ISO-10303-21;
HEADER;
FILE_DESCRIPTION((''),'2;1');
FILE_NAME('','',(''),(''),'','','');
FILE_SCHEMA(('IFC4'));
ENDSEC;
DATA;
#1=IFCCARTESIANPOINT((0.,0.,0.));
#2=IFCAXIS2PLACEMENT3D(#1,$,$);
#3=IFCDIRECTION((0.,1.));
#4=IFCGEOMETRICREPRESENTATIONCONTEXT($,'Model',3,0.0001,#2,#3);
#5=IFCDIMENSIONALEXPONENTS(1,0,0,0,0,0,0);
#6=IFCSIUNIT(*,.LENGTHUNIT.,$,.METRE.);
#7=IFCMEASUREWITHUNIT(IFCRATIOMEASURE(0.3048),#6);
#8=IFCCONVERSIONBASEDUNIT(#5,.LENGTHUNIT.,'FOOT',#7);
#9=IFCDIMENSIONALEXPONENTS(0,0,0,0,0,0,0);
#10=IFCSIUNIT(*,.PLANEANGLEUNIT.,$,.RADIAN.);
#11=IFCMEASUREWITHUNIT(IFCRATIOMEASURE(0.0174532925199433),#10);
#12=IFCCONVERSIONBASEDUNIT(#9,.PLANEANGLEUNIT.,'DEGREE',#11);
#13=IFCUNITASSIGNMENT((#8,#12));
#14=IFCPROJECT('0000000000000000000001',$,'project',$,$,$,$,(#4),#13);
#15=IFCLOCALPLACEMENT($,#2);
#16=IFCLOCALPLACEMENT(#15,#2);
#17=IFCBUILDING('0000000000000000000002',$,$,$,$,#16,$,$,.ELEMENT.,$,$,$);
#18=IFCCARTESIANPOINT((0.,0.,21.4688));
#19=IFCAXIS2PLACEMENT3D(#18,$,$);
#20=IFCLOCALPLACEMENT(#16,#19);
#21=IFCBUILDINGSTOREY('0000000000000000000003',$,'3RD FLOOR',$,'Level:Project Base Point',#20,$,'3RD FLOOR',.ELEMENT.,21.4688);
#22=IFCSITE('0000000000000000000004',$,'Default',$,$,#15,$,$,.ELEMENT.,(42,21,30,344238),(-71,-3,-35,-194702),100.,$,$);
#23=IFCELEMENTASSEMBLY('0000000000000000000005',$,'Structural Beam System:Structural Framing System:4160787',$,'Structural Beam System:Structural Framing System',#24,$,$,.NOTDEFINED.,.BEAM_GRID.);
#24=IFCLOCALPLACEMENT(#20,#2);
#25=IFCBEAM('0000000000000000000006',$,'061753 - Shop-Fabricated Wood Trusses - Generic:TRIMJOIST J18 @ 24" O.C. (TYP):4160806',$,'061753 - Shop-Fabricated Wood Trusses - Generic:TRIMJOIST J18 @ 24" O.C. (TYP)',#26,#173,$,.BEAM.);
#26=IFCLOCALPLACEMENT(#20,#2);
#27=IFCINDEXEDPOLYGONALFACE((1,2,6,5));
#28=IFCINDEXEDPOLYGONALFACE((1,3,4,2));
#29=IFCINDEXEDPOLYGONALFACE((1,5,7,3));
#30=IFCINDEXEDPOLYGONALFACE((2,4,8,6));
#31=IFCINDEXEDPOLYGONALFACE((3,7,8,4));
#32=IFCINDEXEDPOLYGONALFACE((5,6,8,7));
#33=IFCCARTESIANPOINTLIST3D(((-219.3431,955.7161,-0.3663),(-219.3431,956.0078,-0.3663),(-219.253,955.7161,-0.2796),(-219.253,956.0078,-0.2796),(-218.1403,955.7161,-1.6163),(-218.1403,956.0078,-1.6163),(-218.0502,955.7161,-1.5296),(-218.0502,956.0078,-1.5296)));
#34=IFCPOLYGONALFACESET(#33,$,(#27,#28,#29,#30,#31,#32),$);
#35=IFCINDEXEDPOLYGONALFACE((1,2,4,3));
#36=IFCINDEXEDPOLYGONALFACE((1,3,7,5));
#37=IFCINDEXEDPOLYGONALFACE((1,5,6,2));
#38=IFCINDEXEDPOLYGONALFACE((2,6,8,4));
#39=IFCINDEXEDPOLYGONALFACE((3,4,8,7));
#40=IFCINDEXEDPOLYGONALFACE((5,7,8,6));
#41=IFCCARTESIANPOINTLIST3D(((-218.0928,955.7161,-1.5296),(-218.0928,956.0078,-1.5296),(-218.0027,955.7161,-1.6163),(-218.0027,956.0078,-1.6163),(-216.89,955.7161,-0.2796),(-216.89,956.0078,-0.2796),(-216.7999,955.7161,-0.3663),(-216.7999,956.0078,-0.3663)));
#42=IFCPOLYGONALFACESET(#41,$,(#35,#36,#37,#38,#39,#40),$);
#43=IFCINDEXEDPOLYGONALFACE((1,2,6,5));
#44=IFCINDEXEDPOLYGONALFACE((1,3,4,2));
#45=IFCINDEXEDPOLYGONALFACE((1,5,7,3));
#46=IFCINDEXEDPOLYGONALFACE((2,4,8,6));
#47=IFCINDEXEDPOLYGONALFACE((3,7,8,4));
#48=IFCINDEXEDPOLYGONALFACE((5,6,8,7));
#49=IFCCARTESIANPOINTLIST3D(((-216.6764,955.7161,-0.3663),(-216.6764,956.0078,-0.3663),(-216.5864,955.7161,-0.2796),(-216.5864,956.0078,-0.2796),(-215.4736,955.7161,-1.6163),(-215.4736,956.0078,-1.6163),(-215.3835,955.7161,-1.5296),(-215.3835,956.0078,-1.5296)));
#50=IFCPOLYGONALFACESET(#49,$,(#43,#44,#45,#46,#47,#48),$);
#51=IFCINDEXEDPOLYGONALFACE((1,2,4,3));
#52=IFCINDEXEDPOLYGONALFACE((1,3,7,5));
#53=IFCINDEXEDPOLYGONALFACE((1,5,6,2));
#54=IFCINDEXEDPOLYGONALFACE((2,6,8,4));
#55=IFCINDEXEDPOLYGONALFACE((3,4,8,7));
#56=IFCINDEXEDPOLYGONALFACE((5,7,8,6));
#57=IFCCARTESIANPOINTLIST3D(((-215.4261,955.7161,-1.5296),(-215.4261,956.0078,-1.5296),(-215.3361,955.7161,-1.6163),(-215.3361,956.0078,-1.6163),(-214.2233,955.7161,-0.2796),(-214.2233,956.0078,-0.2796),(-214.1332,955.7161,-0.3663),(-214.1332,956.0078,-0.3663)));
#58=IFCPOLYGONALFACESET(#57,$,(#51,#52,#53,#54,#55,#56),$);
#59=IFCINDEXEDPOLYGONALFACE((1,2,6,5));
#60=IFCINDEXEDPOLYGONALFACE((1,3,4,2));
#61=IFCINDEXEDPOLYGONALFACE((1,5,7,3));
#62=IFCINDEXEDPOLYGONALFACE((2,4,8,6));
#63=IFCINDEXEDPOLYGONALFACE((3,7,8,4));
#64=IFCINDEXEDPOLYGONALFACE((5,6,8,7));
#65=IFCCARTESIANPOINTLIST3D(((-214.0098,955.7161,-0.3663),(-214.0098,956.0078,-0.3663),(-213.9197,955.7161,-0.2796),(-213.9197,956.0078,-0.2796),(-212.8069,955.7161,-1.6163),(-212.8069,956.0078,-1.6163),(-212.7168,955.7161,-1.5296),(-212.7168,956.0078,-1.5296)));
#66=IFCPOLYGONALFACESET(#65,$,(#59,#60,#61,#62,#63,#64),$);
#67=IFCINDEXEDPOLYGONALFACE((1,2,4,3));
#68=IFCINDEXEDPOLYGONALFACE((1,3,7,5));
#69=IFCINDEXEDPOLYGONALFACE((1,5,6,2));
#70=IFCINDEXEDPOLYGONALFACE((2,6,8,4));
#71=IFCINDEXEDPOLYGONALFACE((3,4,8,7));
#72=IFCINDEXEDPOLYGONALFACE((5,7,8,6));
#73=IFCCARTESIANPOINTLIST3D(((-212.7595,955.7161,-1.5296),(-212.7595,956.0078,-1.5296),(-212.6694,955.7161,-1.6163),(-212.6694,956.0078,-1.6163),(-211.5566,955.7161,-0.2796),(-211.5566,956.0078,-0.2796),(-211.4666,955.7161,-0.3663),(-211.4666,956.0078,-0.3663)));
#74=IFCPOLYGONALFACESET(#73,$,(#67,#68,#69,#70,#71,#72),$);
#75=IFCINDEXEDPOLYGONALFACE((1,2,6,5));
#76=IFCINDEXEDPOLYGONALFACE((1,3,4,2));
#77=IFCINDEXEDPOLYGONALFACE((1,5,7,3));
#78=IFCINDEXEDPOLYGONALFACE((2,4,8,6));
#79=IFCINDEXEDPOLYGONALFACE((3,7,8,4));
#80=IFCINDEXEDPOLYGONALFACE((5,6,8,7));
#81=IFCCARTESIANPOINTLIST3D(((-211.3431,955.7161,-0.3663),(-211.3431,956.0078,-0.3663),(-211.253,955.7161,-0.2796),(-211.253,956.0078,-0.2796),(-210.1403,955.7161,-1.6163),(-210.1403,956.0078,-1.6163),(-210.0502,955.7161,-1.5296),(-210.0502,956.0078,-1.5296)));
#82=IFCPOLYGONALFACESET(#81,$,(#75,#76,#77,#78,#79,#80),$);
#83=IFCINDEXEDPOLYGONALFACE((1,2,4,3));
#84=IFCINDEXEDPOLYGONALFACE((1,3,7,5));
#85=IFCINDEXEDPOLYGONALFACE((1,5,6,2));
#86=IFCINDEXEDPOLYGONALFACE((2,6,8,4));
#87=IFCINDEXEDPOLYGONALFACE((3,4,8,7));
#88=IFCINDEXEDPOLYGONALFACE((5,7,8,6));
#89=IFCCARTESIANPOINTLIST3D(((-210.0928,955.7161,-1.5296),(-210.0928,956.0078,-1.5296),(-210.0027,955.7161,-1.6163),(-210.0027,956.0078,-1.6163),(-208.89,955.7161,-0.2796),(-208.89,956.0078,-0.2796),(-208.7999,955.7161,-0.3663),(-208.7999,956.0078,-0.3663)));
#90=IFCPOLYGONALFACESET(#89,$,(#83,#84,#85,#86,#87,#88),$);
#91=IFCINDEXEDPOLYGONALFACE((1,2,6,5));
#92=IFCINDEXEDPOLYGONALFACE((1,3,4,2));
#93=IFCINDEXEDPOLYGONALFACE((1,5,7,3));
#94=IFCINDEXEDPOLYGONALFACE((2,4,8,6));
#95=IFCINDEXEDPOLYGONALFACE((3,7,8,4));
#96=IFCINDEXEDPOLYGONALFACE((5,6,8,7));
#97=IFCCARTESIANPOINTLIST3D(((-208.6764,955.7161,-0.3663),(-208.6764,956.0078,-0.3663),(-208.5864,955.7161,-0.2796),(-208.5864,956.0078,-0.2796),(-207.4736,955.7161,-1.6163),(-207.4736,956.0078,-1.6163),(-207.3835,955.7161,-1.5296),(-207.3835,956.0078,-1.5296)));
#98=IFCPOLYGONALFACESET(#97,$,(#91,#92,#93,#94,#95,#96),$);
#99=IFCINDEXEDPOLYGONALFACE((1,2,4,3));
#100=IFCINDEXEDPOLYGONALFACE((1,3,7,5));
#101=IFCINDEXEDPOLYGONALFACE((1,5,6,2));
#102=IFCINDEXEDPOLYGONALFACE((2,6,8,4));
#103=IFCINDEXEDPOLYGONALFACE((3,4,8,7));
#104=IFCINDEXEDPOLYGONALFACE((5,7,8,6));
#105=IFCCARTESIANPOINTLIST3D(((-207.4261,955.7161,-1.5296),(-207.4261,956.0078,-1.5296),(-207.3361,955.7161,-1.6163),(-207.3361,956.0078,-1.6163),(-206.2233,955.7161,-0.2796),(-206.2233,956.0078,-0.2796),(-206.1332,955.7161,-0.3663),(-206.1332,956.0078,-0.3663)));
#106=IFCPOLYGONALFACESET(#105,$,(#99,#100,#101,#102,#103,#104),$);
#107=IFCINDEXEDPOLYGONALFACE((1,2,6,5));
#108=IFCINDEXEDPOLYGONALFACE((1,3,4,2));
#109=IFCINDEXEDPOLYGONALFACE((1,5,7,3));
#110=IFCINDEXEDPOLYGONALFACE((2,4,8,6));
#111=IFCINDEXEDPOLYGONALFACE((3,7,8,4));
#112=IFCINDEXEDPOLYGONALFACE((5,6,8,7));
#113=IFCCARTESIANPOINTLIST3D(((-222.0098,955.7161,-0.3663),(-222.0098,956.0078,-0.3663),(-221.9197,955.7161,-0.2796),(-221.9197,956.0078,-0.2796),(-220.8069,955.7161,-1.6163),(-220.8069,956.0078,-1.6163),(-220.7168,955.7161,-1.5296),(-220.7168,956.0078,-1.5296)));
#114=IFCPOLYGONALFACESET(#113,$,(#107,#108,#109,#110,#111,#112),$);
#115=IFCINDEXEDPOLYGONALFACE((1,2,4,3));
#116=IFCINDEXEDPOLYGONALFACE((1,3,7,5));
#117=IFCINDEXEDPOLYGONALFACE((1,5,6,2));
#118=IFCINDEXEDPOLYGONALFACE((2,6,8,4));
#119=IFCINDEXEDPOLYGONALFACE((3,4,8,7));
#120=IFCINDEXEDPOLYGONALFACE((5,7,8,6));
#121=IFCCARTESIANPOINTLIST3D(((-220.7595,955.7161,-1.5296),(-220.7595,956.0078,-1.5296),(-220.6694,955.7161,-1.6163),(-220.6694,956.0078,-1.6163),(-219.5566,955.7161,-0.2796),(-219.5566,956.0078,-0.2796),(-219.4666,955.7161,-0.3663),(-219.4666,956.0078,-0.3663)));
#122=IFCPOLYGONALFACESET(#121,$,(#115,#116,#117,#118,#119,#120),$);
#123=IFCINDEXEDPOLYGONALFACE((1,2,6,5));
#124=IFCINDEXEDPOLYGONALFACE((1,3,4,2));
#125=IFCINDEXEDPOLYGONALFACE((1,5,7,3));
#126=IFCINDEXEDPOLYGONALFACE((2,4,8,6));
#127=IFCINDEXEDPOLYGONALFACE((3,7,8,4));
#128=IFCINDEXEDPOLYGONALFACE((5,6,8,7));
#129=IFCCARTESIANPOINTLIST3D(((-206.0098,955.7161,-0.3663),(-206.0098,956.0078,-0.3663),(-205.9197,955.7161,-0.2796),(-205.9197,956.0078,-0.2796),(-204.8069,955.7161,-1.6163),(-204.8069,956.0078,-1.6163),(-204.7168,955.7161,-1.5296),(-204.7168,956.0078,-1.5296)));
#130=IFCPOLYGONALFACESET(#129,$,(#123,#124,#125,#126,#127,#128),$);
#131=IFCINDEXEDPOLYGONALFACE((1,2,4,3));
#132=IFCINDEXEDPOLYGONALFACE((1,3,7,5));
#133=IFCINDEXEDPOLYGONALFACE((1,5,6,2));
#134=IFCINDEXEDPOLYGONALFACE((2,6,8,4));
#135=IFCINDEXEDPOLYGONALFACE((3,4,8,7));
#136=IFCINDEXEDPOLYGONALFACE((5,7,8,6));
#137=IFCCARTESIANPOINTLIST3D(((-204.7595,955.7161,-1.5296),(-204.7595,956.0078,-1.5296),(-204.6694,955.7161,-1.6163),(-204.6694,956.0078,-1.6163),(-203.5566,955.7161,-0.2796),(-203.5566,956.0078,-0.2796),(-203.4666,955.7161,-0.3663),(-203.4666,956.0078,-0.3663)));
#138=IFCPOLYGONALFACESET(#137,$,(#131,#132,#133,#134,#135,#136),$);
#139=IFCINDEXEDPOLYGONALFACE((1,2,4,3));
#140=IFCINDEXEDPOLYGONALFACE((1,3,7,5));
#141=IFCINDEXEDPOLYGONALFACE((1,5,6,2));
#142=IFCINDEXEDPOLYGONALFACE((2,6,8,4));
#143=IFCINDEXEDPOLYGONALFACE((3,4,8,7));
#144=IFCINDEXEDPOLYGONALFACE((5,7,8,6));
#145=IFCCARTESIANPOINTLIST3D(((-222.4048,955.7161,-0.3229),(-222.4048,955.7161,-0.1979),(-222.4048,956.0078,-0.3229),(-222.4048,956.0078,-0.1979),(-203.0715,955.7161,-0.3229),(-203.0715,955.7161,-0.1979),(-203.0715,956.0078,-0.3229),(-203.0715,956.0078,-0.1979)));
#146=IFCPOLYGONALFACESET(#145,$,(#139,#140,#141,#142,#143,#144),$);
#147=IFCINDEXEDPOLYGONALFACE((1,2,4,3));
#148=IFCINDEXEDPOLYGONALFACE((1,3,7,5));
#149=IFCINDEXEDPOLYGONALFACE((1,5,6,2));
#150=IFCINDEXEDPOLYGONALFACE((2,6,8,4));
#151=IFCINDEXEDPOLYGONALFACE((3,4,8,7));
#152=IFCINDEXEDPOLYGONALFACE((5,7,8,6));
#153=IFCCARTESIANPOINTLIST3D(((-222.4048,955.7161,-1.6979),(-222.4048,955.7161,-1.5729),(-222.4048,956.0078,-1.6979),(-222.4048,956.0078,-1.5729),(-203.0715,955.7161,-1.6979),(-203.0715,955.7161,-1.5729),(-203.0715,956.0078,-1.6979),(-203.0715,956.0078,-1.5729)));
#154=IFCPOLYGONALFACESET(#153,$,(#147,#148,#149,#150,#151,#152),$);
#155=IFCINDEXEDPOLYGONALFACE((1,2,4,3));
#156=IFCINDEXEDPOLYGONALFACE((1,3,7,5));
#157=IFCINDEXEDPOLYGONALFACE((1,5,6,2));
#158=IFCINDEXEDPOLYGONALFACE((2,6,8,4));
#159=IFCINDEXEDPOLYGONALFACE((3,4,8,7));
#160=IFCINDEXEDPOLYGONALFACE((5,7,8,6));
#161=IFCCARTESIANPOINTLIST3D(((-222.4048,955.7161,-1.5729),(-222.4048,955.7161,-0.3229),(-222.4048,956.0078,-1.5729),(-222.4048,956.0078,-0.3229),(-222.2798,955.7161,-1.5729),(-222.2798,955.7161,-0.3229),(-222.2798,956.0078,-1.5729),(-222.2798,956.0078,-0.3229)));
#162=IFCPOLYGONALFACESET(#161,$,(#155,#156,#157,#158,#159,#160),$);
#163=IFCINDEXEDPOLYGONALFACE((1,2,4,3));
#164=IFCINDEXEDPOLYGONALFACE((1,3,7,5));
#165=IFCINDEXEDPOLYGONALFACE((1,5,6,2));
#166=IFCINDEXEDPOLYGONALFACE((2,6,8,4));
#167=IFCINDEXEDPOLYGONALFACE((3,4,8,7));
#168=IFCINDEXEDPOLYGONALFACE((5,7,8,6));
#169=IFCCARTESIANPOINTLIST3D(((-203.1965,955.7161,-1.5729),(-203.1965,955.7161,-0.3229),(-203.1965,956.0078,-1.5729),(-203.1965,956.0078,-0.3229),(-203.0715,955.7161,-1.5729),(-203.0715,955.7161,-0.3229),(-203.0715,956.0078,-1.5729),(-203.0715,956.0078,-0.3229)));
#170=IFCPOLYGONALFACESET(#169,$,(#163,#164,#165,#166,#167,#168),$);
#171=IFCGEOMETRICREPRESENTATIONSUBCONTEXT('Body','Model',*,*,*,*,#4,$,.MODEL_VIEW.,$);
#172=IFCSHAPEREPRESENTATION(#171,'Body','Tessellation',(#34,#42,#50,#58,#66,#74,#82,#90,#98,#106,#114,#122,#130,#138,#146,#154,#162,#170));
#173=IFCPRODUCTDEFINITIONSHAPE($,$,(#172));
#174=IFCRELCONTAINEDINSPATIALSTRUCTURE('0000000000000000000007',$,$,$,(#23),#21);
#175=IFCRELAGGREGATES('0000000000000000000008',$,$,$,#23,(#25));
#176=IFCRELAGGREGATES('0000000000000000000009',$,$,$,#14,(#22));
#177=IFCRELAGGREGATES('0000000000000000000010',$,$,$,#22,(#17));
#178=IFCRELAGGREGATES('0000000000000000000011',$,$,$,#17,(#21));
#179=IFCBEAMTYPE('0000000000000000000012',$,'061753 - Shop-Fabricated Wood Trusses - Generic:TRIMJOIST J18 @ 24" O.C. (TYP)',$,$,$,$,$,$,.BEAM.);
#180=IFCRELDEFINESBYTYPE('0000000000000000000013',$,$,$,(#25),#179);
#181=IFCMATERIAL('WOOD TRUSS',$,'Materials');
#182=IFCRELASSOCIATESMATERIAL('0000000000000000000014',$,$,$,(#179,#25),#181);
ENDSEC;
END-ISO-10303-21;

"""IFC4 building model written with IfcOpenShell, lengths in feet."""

from ifc_helpers import new_model, entity, si_unit, converted_unit, direction, frame, frame_2d, origin, origin_2d_with_axis, place, context, subcontext, project, spatial, rectangle, extrude, source, transform, mapped, material, material_profile, profile_set, profile_usage, type_object, type_shapes, element, aggregate, save


model = new_model("IFC4")

# Units and contexts
model_context = context("Model", 3, precision=0.0001, world=origin(), true_north=direction((0.0, 1.0)))
body_context = subcontext(model_context, "Body", "Model", "MODEL_VIEW")
ifc_project = project(units=[converted_unit("LENGTHUNIT", "FOOT", entity("IfcRatioMeasure", 0.3048), si_unit("LENGTHUNIT", "METRE"), dimensions=[1, 0, 0, 0, 0, 0, 0]), converted_unit("PLANEANGLEUNIT", "DEGREE", entity("IfcRatioMeasure", 0.0174532925199433), si_unit("PLANEANGLEUNIT", "RADIAN"), dimensions=[0, 0, 0, 0, 0, 0, 0])], contexts=[model_context])

# Site, building, storey
site_placement = place(None, origin())
site = spatial("IfcSite", under=ifc_project, at=site_placement, Name="Default", CompositionType="ELEMENT", RefLatitude=(42, 21, 30, 344238), RefLongitude=(-71, -3, -35, -194702), RefElevation=100.0)
building_placement = place(site_placement, origin())
building = spatial("IfcBuilding", under=site, at=building_placement, CompositionType="ELEMENT")
storey_placement = place(building_placement, frame((0.0, 0.0, 21.4688)))
storey = spatial("IfcBuildingStorey", under=building, at=storey_placement, Name="3RD FLOOR", ObjectType="Level:Project Base Point", LongName="3RD FLOOR", CompositionType="ELEMENT", Elevation=21.4688)

# Element assembly, beam
ifc_material_1 = material(Name="WOOD TRUSS", Category="Materials")
ifc_material_profile_1 = material_profile(ifc_material_1, rectangle(XDim=1.7347, YDim=0.125, at=frame_2d((0.0, 0.0), x_axis=(1.0, 0.0))), Name="TRIMJOIST J18 @ 24\" O.C. (TYP)")
ifc_material_profile_2 = material_profile(ifc_material_1, rectangle(XDim=1.7347, YDim=0.125, at=frame_2d((0.0, 0.0), x_axis=(1.0, 0.0))), Name="TRIMJOIST J18 @ 24\" O.C. (TYP)")
ifc_material_profile_3 = material_profile(ifc_material_1, rectangle(XDim=1.7347, YDim=0.125, at=frame_2d((0.0, 0.0), x_axis=(1.0, 0.0))), Name="TRIMJOIST J18 @ 24\" O.C. (TYP)")
ifc_material_profile_4 = material_profile(ifc_material_1, rectangle(XDim=1.7347, YDim=0.125, at=frame_2d((0.0, 0.0), x_axis=(1.0, 0.0))), Name="TRIMJOIST J18 @ 24\" O.C. (TYP)")
ifc_material_profile_5 = material_profile(ifc_material_1, rectangle(XDim=1.7347, YDim=0.125, at=frame_2d((0.0, 0.0), x_axis=(1.0, 0.0))), Name="TRIMJOIST J18 @ 24\" O.C. (TYP)")
ifc_material_profile_6 = material_profile(ifc_material_1, rectangle(XDim=1.7347, YDim=0.125, at=frame_2d((0.0, 0.0), x_axis=(1.0, 0.0))), Name="TRIMJOIST J18 @ 24\" O.C. (TYP)")
ifc_material_profile_7 = material_profile(ifc_material_1, rectangle(XDim=1.7347, YDim=0.125, at=frame_2d((0.0, 0.0), x_axis=(1.0, 0.0))), Name="TRIMJOIST J18 @ 24\" O.C. (TYP)")
ifc_material_profile_8 = material_profile(ifc_material_1, rectangle(XDim=1.7347, YDim=0.125, at=frame_2d((0.0, 0.0), x_axis=(1.0, 0.0))), Name="TRIMJOIST J18 @ 24\" O.C. (TYP)")
ifc_material_profile_9 = material_profile(ifc_material_1, rectangle(XDim=1.7347, YDim=0.125, at=frame_2d((0.0, 0.0), x_axis=(1.0, 0.0))), Name="TRIMJOIST J18 @ 24\" O.C. (TYP)")
ifc_material_profile_10 = material_profile(ifc_material_1, rectangle(XDim=1.7347, YDim=0.125, at=origin_2d_with_axis()), Name="TRIMJOIST J18 @ 24\" O.C. (TYP)")
ifc_material_profile_11 = material_profile(ifc_material_1, rectangle(XDim=0.125, YDim=0.2917, at=origin_2d_with_axis()), Name="TRIMJOIST J18 @ 24\" O.C. (TYP)")
ifc_material_profile_12 = material_profile(ifc_material_1, rectangle(XDim=0.125, YDim=0.2917, at=origin_2d_with_axis()), Name="TRIMJOIST J18 @ 24\" O.C. (TYP)")
ifc_material_profile_13 = material_profile(ifc_material_1, rectangle(XDim=1.25, YDim=0.2917, at=origin_2d_with_axis()), Name="TRIMJOIST J18 @ 24\" O.C. (TYP)")
ifc_material_profile_14 = material_profile(ifc_material_1, rectangle(XDim=1.25, YDim=0.2917, at=origin_2d_with_axis()), Name="TRIMJOIST J18 @ 24\" O.C. (TYP)")
ifc_profile_set_1 = profile_set([ifc_material_profile_1, ifc_material_profile_2, ifc_material_profile_3, ifc_material_profile_4, ifc_material_profile_5, ifc_material_profile_6, ifc_material_profile_7, ifc_material_profile_8, ifc_material_profile_9, ifc_material_profile_10, ifc_material_profile_11, ifc_material_profile_12, ifc_material_profile_13, ifc_material_profile_14], Name="TRIMJOIST J18 @ 24\" O.C. (TYP)")
beam_type_1 = type_object("IfcBeamType", Name="061753 - Shop-Fabricated Wood Trusses - Generic:TRIMJOIST J18 @ 24\" O.C. (TYP)", PredefinedType="BEAM", material=ifc_profile_set_1)
shared_shape_1 = source(origin(), body_context, "Body", "SweptSolid", [
    extrude(rectangle(XDim=1.7347, YDim=0.125, at=frame_2d((0.0, 0.0), x_axis=(1.0, 0.0))), frame((5.9585, -0.1458, 0.0), z_axis=(0.0, 1.0, 0.0), x_axis=(0.693383, 0.0, 0.720569)), (0.0, 0.0, 1.0), 0.2917),
    extrude(rectangle(XDim=1.7347, YDim=0.125, at=origin_2d_with_axis()), frame((4.7082, -0.1458, 0.0), z_axis=(0.0, 1.0, 0.0), x_axis=(0.693383, 0.0, -0.720569)), (0.0, 0.0, 1.0), 0.2917),
    extrude(rectangle(XDim=1.7347, YDim=0.125, at=frame_2d((0.0, 0.0), x_axis=(1.0, 0.0))), frame((3.2918, -0.1458, 0.0), z_axis=(0.0, 1.0, 0.0), x_axis=(0.693383, 0.0, 0.720569)), (0.0, 0.0, 1.0), 0.2917),
    extrude(rectangle(XDim=1.7347, YDim=0.125, at=frame_2d((0.0, 0.0), x_axis=(1.0, 0.0))), frame((2.0415, -0.1458, 0.0), z_axis=(0.0, 1.0, 0.0), x_axis=(0.693383, 0.0, -0.720569)), (0.0, 0.0, 1.0), 0.2917),
    extrude(rectangle(XDim=1.7347, YDim=0.125, at=frame_2d((0.0, 0.0), x_axis=(1.0, 0.0))), frame((0.6251, -0.1458, 0.0), z_axis=(0.0, 1.0, 0.0), x_axis=(0.693383, 0.0, 0.720569)), (0.0, 0.0, 1.0), 0.2917),
    extrude(rectangle(XDim=1.7347, YDim=0.125, at=frame_2d((0.0, 0.0), x_axis=(1.0, 0.0))), frame((-0.6251, -0.1458, 0.0), z_axis=(0.0, 1.0, 0.0), x_axis=(0.693383, 0.0, -0.720569)), (0.0, 0.0, 1.0), 0.2917),
    extrude(rectangle(XDim=1.7347, YDim=0.125, at=frame_2d((0.0, 0.0), x_axis=(1.0, 0.0))), frame((-2.0415, -0.1458, 0.0), z_axis=(0.0, 1.0, 0.0), x_axis=(0.693383, 0.0, 0.720569)), (0.0, 0.0, 1.0), 0.2917),
    extrude(rectangle(XDim=1.7347, YDim=0.125, at=origin_2d_with_axis()), frame((-3.2918, -0.1458, 0.0), z_axis=(0.0, 1.0, 0.0), x_axis=(0.693383, 0.0, -0.720569)), (0.0, 0.0, 1.0), 0.2917),
    extrude(rectangle(XDim=1.7347, YDim=0.125, at=frame_2d((0.0, 0.0), x_axis=(1.0, 0.0))), frame((-4.7082, -0.1458, 0.0), z_axis=(0.0, 1.0, 0.0), x_axis=(0.693383, 0.0, 0.720569)), (0.0, 0.0, 1.0), 0.2917),
    extrude(rectangle(XDim=1.7347, YDim=0.125, at=frame_2d((0.0, 0.0), x_axis=(1.0, 0.0))), frame((-5.9585, -0.1458, 0.0), z_axis=(0.0, 1.0, 0.0), x_axis=(0.693383, 0.0, -0.720569)), (0.0, 0.0, 1.0), 0.2917),
    extrude(rectangle(XDim=1.7347, YDim=0.125, at=frame_2d((0.0, 0.0), x_axis=(1.0, 0.0))), frame((8.6251, -0.1458, 0.0), z_axis=(0.0, 1.0, 0.0), x_axis=(0.693383, 0.0, 0.720569)), (0.0, 0.0, 1.0), 0.2917),
    extrude(rectangle(XDim=1.7347, YDim=0.125, at=origin_2d_with_axis()), frame((7.3749, -0.1458, 0.0), z_axis=(0.0, 1.0, 0.0), x_axis=(0.693383, 0.0, -0.720569)), (0.0, 0.0, 1.0), 0.2917),
    extrude(rectangle(XDim=1.7347, YDim=0.125, at=frame_2d((0.0, 0.0), x_axis=(1.0, 0.0))), frame((-7.3749, -0.1458, 0.0), z_axis=(0.0, 1.0, 0.0), x_axis=(0.693383, 0.0, 0.720569)), (0.0, 0.0, 1.0), 0.2917),
    extrude(rectangle(XDim=1.7347, YDim=0.125, at=origin_2d_with_axis()), frame((-8.6251, -0.1458, 0.0), z_axis=(0.0, 1.0, 0.0), x_axis=(0.693383, 0.0, -0.720569)), (0.0, 0.0, 1.0), 0.2917),
    extrude(rectangle(XDim=0.125, YDim=0.2917, at=origin_2d_with_axis()), frame((-9.6667, 0.0, 0.6875), z_axis=(1.0, 0.0, 0.0), x_axis=(0.0, 0.0, -1.0)), (0.0, 0.0, 1.0), 19.3333),
    extrude(rectangle(XDim=0.125, YDim=0.2917, at=origin_2d_with_axis()), frame((-9.6667, 0.0, -0.6875), z_axis=(1.0, 0.0, 0.0), x_axis=(0.0, 0.0, -1.0)), (0.0, 0.0, 1.0), 19.3333),
    extrude(rectangle(XDim=1.25, YDim=0.2917, at=origin_2d_with_axis()), frame((9.5417, 0.0, 0.0), z_axis=(1.0, 0.0, 0.0), x_axis=(0.0, 0.0, -1.0)), (0.0, 0.0, 1.0), 0.125),
    extrude(rectangle(XDim=1.25, YDim=0.2917, at=origin_2d_with_axis()), frame((-9.6667, 0.0, 0.0), z_axis=(1.0, 0.0, 0.0), x_axis=(0.0, 0.0, -1.0)), (0.0, 0.0, 1.0), 0.125),
])
type_shapes(beam_type_1, [shared_shape_1])
assembly_1_placement = place(storey_placement, origin())
assembly_1 = element("IfcElementAssembly", 1, at=assembly_1_placement, inside=storey, Name="Structural Beam System:Structural Framing System:4160787", ObjectType="Structural Beam System:Structural Framing System", AssemblyPlace="NOTDEFINED", PredefinedType="BEAM_GRID")
ifc_profile_usage_1 = profile_usage(ifc_profile_set_1, cardinal=8)
beam_1_placement = place(assembly_1_placement, frame((-212.7382, 955.8619, -0.9479), z_axis=(0.0, 0.0, 1.0), x_axis=(-1.0, 0.0, 0.0)))
beam_1 = element("IfcBeam", 2, at=beam_1_placement, type_object=beam_type_1, material=ifc_profile_usage_1, Name="061753 - Shop-Fabricated Wood Trusses - Generic:TRIMJOIST J18 @ 24\" O.C. (TYP):4160806", ObjectType="061753 - Shop-Fabricated Wood Trusses - Generic:TRIMJOIST J18 @ 24\" O.C. (TYP)", PredefinedType="BEAM", context=body_context, shape_type="MappedRepresentation", body=[
    mapped(shared_shape_1, transform((0.0, 0.0, 0.0), scale=1.0)),
])
aggregate(assembly_1, [beam_1])

save(model, "model.ifc")
